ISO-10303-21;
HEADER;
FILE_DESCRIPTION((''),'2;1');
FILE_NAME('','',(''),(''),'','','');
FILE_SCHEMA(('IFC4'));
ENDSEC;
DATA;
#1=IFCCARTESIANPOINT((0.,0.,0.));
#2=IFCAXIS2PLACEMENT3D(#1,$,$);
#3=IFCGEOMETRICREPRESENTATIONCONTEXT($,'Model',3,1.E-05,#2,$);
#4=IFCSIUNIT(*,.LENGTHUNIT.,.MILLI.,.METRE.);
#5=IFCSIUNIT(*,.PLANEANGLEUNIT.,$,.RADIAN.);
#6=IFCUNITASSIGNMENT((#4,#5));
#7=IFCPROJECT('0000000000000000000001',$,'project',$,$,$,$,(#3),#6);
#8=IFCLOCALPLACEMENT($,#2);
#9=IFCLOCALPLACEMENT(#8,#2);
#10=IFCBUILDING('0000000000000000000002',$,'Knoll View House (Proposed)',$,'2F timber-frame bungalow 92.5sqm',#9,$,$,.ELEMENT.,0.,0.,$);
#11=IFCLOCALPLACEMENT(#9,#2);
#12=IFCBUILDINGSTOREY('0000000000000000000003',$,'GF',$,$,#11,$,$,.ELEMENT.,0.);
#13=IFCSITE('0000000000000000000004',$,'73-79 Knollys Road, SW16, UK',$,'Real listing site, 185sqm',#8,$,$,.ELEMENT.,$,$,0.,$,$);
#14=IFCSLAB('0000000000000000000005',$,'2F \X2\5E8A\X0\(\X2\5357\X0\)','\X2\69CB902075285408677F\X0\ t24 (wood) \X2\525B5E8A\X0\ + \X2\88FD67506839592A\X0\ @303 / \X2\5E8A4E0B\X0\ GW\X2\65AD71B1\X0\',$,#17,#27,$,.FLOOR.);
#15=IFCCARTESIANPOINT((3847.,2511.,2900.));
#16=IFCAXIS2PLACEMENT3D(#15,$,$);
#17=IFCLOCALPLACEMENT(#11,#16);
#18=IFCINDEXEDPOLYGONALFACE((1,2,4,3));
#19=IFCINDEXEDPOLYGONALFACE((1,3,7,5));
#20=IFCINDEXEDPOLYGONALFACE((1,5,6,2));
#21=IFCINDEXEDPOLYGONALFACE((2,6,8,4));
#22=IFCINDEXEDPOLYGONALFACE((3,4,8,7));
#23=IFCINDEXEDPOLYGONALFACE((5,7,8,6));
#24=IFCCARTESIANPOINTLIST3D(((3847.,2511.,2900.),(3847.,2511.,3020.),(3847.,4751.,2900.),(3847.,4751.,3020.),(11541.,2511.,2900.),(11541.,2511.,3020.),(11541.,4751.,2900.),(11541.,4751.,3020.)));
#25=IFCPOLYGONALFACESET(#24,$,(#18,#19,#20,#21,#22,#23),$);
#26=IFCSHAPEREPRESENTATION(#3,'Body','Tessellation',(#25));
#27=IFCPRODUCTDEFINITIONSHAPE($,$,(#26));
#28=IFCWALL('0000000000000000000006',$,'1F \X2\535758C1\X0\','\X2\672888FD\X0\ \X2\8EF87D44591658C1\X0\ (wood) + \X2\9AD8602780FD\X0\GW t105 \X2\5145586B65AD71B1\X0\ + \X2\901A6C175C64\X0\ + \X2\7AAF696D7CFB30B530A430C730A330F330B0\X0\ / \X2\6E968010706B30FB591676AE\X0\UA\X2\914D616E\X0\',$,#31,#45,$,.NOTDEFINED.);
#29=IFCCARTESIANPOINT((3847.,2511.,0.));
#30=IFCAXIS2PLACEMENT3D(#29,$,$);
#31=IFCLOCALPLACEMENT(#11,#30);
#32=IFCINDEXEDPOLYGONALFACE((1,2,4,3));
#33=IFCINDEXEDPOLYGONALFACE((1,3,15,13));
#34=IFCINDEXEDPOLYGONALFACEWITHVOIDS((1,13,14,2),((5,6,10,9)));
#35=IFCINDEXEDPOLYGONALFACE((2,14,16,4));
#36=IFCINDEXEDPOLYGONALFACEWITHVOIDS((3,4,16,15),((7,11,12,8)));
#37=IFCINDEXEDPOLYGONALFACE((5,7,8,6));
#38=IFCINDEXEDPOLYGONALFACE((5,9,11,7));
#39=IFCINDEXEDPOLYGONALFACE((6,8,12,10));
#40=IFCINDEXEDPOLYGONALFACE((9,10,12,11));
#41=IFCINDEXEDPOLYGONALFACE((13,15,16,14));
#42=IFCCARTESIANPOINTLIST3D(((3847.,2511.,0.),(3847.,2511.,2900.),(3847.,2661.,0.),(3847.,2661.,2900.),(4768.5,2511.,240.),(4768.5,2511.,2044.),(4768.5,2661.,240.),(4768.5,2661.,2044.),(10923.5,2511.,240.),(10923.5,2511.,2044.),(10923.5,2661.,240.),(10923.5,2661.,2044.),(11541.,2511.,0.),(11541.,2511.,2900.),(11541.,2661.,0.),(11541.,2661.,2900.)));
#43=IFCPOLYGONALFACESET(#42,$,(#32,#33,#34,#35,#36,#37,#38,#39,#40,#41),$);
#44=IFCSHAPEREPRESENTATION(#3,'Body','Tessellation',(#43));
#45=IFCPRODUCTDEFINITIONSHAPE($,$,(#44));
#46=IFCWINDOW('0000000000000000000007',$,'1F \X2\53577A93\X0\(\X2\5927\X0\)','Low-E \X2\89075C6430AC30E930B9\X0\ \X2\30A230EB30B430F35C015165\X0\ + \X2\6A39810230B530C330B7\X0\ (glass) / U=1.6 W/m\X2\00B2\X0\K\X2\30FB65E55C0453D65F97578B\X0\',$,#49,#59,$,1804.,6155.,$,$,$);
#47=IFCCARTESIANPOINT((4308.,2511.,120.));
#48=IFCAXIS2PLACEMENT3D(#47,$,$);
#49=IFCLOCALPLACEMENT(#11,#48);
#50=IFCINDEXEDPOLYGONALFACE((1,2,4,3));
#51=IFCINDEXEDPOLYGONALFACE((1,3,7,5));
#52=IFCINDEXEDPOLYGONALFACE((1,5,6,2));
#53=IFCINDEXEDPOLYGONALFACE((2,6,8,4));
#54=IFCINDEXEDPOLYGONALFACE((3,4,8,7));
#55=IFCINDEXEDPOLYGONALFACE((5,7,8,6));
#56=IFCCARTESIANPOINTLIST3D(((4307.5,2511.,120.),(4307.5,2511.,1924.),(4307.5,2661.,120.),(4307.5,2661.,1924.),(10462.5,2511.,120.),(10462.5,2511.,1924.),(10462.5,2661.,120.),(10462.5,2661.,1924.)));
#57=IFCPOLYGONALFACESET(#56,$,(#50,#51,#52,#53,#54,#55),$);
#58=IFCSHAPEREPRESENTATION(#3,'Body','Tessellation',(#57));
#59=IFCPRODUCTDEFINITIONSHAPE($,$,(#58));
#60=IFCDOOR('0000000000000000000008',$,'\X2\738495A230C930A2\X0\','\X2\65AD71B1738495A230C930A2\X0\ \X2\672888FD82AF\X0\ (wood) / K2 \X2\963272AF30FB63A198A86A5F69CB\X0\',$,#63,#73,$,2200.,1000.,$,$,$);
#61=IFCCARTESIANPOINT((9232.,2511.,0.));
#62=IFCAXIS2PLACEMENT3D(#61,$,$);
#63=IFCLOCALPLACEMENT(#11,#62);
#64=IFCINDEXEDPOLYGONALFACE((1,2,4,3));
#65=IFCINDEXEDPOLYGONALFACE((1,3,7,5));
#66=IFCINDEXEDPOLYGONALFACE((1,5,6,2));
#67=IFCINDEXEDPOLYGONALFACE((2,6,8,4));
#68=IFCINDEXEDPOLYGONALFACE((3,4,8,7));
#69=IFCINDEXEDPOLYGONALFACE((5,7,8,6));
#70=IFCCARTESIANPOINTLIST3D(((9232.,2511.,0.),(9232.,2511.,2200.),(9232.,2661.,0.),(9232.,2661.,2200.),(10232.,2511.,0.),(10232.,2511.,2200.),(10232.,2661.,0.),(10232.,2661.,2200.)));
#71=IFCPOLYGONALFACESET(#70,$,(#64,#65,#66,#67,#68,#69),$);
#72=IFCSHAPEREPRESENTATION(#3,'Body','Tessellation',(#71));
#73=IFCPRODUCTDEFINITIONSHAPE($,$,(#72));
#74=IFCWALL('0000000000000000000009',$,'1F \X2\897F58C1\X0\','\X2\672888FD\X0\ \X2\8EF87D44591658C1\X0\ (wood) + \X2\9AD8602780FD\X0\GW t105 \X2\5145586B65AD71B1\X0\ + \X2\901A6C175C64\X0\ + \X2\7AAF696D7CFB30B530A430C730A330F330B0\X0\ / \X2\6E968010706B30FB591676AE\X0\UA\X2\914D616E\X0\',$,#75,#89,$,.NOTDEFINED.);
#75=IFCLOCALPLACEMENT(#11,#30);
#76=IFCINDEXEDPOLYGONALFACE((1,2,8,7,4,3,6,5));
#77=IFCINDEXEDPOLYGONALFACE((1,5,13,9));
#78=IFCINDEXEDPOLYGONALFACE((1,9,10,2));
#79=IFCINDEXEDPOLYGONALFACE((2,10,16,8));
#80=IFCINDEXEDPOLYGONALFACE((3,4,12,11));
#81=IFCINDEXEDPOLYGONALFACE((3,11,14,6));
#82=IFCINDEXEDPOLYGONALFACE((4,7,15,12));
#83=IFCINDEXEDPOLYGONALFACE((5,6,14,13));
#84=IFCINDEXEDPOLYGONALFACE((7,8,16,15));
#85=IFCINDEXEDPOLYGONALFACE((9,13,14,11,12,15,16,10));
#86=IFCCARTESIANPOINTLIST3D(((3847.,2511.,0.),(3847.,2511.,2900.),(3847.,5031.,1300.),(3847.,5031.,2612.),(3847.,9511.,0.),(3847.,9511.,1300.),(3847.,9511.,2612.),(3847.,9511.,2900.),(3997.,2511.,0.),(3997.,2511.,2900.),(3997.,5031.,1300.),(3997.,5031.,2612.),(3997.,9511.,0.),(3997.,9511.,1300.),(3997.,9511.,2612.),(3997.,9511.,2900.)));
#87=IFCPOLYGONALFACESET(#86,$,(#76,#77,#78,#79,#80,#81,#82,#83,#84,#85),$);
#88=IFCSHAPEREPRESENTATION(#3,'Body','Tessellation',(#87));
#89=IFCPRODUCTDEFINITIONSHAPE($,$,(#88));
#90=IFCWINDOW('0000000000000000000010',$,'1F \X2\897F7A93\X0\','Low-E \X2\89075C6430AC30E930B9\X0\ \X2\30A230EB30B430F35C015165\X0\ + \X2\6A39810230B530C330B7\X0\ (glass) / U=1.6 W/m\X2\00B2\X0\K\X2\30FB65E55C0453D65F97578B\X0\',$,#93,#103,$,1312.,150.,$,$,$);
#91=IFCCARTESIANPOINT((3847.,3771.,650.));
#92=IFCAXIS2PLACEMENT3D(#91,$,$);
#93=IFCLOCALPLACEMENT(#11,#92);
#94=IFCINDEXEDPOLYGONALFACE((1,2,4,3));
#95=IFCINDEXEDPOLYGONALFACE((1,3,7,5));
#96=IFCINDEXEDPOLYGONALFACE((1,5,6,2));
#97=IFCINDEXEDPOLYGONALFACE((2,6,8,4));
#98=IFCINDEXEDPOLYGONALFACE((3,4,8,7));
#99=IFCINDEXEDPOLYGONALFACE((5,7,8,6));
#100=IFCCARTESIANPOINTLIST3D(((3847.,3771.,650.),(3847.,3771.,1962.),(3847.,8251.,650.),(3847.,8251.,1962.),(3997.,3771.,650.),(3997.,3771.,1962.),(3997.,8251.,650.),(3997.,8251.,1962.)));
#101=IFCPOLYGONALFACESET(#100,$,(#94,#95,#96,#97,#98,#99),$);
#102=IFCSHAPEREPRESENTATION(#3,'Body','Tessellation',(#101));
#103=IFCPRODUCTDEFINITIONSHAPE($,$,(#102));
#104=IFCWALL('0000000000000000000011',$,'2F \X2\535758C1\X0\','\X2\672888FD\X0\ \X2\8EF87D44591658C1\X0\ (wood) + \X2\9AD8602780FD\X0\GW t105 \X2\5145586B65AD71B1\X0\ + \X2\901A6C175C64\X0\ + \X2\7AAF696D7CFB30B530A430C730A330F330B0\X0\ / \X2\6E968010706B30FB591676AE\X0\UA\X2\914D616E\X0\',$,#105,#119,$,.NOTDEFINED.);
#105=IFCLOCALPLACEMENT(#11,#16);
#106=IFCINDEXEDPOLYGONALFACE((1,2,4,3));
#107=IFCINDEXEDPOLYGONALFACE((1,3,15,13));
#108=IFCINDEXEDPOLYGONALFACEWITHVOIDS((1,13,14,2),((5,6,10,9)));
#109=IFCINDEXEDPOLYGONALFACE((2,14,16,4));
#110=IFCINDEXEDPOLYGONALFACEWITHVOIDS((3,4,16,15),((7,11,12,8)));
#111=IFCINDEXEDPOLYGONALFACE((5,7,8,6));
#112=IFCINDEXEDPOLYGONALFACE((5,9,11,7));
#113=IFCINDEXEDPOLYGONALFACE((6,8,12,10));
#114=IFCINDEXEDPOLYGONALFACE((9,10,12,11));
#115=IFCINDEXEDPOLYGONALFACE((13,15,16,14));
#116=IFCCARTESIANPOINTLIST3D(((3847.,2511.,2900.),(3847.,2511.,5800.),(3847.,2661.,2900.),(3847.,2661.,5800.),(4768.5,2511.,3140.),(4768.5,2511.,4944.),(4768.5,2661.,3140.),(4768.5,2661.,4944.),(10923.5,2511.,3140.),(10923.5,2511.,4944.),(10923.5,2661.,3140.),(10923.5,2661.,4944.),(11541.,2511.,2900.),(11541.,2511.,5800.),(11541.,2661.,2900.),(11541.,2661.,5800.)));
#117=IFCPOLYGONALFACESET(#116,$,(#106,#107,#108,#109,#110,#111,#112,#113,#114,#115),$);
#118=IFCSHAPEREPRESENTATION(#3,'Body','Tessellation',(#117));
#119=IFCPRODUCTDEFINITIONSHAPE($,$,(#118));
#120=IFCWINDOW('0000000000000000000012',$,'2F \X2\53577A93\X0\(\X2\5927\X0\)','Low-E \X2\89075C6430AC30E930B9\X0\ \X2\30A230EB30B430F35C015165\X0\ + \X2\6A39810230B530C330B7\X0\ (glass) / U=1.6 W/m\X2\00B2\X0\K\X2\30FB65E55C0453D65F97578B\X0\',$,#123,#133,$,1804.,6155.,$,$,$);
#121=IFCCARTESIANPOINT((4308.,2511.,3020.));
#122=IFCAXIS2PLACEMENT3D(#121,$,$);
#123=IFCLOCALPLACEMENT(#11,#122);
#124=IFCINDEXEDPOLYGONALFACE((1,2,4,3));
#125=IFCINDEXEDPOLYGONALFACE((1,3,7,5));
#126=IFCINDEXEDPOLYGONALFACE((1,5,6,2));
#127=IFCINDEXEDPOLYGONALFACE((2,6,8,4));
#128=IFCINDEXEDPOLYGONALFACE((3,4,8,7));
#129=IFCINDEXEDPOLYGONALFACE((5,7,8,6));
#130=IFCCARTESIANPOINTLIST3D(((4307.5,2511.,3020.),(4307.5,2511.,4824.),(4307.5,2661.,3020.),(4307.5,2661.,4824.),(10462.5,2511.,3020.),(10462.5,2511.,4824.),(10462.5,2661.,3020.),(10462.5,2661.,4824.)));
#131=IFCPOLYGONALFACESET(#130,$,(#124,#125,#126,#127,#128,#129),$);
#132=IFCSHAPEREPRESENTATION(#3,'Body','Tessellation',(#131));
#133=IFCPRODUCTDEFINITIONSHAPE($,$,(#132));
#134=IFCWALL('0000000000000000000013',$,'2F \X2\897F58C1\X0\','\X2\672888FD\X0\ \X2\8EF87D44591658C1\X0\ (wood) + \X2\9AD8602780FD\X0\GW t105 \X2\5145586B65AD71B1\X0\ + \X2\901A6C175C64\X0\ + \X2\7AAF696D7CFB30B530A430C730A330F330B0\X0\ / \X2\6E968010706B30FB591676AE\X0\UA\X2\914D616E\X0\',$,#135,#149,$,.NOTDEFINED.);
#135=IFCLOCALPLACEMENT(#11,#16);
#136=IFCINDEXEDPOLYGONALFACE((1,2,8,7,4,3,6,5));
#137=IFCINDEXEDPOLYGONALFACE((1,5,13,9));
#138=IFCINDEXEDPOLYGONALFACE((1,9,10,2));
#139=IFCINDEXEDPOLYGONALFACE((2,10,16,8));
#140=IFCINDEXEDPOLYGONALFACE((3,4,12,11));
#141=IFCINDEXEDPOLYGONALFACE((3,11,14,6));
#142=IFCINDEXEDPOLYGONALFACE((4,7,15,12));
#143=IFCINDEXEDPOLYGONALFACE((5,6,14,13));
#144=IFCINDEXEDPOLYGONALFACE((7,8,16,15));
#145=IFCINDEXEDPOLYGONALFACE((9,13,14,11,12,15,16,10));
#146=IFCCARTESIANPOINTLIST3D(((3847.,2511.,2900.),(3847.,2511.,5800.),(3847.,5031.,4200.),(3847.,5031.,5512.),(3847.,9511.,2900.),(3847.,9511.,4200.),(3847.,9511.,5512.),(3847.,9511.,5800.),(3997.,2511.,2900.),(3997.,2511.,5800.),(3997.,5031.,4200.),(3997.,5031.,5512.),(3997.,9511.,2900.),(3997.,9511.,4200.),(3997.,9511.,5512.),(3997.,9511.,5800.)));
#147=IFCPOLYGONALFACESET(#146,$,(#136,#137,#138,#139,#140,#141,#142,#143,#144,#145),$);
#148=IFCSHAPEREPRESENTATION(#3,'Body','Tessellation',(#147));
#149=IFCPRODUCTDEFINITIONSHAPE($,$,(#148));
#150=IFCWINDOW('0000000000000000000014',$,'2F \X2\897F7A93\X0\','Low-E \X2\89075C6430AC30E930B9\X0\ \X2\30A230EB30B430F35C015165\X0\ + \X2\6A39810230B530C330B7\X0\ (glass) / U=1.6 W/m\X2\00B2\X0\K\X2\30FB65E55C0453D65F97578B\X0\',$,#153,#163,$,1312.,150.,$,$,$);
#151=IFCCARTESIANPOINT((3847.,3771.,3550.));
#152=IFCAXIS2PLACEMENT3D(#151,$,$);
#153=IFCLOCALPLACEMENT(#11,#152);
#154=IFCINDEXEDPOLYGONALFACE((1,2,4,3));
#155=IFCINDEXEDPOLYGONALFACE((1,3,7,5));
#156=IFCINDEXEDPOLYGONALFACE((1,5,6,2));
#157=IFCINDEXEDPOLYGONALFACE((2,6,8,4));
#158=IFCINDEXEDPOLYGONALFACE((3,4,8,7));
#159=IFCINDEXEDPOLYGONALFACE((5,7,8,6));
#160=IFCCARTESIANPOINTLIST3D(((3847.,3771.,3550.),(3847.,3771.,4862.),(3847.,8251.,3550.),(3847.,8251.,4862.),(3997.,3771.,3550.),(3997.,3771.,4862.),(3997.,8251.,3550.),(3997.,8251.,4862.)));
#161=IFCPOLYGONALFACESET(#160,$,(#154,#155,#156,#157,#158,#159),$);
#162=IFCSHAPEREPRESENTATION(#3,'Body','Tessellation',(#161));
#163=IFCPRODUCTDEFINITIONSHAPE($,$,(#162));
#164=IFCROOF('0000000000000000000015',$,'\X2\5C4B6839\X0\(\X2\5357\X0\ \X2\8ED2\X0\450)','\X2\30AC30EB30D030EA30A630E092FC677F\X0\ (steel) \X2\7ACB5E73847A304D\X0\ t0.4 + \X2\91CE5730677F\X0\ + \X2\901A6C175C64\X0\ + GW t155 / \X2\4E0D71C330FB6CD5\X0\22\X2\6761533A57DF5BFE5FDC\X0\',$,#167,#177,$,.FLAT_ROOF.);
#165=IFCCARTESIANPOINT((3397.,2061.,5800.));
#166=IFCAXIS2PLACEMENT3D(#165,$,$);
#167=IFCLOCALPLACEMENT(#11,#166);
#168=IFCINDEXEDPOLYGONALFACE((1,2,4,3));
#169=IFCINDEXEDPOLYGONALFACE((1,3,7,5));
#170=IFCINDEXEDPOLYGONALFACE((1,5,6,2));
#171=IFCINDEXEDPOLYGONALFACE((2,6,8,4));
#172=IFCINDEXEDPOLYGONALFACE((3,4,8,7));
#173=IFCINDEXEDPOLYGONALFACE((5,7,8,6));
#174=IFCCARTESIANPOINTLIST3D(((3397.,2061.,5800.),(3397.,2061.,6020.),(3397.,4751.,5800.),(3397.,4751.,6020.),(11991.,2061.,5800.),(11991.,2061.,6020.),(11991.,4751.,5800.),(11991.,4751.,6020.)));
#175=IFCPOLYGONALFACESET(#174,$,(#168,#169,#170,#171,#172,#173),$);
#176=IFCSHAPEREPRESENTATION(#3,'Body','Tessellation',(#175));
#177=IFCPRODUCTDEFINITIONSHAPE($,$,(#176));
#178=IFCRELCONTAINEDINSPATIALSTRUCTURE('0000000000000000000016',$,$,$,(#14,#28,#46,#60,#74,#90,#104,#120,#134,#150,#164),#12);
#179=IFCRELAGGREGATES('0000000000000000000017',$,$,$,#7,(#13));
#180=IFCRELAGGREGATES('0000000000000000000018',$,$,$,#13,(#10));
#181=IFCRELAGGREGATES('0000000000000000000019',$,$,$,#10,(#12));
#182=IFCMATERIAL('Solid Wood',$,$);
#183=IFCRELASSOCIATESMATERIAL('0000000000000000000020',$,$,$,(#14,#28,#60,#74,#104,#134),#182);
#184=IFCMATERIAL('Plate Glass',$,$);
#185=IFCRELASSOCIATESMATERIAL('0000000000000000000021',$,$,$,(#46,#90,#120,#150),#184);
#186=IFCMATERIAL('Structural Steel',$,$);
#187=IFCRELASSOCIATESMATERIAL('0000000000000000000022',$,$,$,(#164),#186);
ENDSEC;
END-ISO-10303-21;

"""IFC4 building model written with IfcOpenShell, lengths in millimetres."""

from ifc_helpers import new_model, si_unit, frame, frame_2d, origin, place, context, project, spatial, rectangle, extrude, material, element, fill, save


model = new_model("IFC4")

# Units and contexts
model_context = context("Model", 3, precision=1e-05, world=origin())
ifc_project = project(units=[si_unit("LENGTHUNIT", "METRE", prefix="MILLI"), si_unit("PLANEANGLEUNIT", "RADIAN")], contexts=[model_context])

# Site, building, storey
site_placement = place(None, origin())
site = spatial("IfcSite", under=ifc_project, at=site_placement, Name="73-79 Knollys Road, SW16, UK", ObjectType="Real listing site, 185sqm", CompositionType="ELEMENT", RefElevation=0.0)
building_placement = place(site_placement, origin())
building = spatial("IfcBuilding", under=site, at=building_placement, Name="Knoll View House (Proposed)", ObjectType="2F timber-frame bungalow 92.5sqm", CompositionType="ELEMENT", ElevationOfRefHeight=0.0, ElevationOfTerrain=0.0)
storey_placement = place(building_placement, origin())
storey = spatial("IfcBuildingStorey", under=building, at=storey_placement, Name="GF", CompositionType="ELEMENT", Elevation=0.0)

# Slab
ifc_material_1 = material(Name="Solid Wood")
slab_1_placement = place(storey_placement, frame((3847.0, 2511.0, 2900.0)))
element("IfcSlab", 1, at=slab_1_placement, inside=storey, material=ifc_material_1, Name="2F 床(南)", Description="構造用合板 t24 (wood) 剛床 + 製材根太 @303 / 床下 GW断熱", PredefinedType="FLOOR", context=model_context, shape_type="SweptSolid", body=[
    extrude(rectangle(XDim=7694.0, YDim=2240.0, at=frame_2d((3847.0, 1120.0))), frame((3847.0, 2511.0, 2900.0)), (0.0, 0.0, 1.0), 120.0),
])

# Wall, openings, window, door
wall_1_placement = place(storey_placement, frame((3847.0, 2511.0, 0.0)))
wall_1 = element("IfcWall", 2, at=wall_1_placement, inside=storey, material=ifc_material_1, Name="1F 南壁", Description="木製 軸組外壁 (wood) + 高性能GW t105 充填断熱 + 通気層 + 窯業系サイディング / 準耐火・外皮UA配慮", PredefinedType="NOTDEFINED", context=model_context, shape_type="SweptSolid", body=[
    extrude(rectangle(XDim=7694.0, YDim=150.0, at=frame_2d((3847.0, 75.0))), frame((3847.0, 2511.0, 0.0)), (0.0, 0.0, 1.0), 2900.0),
])
opening_1_placement = place(storey_placement, frame((4308.0, 2511.0, 120.0)))
opening_1 = element("IfcOpeningElement", 3, at=opening_1_placement, cuts=wall_1, PredefinedType="NOTDEFINED", context=model_context, shape_type="SweptSolid", body=[
    extrude(rectangle(XDim=6155.0, YDim=150.0, at=frame_2d((3077.0, 75.0))), frame((4308.0, 2511.0, 120.0)), (0.0, 0.0, 1.0), 1804.0),
])
opening_2_placement = place(storey_placement, frame((9232.0, 2511.0, 0.0)))
opening_2 = element("IfcOpeningElement", 4, at=opening_2_placement, cuts=wall_1, PredefinedType="NOTDEFINED", context=model_context, shape_type="SweptSolid", body=[
    extrude(rectangle(XDim=1000.0, YDim=150.0, at=frame_2d((500.0, 75.0))), frame((9232.0, 2511.0, 0.0)), (0.0, 0.0, 1.0), 2200.0),
])
ifc_material_2 = material(Name="Plate Glass")
window_1_placement = place(storey_placement, frame((4308.0, 2511.0, 120.0)))
window_1 = element("IfcWindow", 5, at=window_1_placement, inside=storey, material=ifc_material_2, Name="1F 南窓(大)", Description="Low-E 複層ガラス アルゴン封入 + 樹脂サッシ (glass) / U=1.6 W/m²K・日射取得型", OverallHeight=1804.0, OverallWidth=6155.0, context=model_context, shape_type="SweptSolid", body=[
    extrude(rectangle(XDim=6155.0, YDim=150.0, at=frame_2d((3077.0, 75.0))), frame((4308.0, 2511.0, 120.0)), (0.0, 0.0, 1.0), 1804.0),
])
fill(opening_1, window_1)
door_placement = place(storey_placement, frame((9232.0, 2511.0, 0.0)))
door = element("IfcDoor", 6, at=door_placement, inside=storey, material=ifc_material_1, Name="玄関ドア", Description="断熱玄関ドア 木製芯 (wood) / K2 防犯・採風機構", OverallHeight=2200.0, OverallWidth=1000.0, context=model_context, shape_type="SweptSolid", body=[
    extrude(rectangle(XDim=1000.0, YDim=150.0, at=frame_2d((500.0, 75.0))), frame((9232.0, 2511.0, 0.0)), (0.0, 0.0, 1.0), 2200.0),
])
fill(opening_2, door)

# Walls, openings, windows
wall_2_placement = place(storey_placement, frame((3847.0, 2511.0, 0.0)))
wall_2 = element("IfcWall", 7, at=wall_2_placement, inside=storey, material=ifc_material_1, Name="1F 西壁", Description="木製 軸組外壁 (wood) + 高性能GW t105 充填断熱 + 通気層 + 窯業系サイディング / 準耐火・外皮UA配慮", PredefinedType="NOTDEFINED", context=model_context, shape_type="SweptSolid", body=[
    extrude(rectangle(XDim=150.0, YDim=7000.0, at=frame_2d((75.0, 3500.0))), frame((3847.0, 2511.0, 0.0)), (0.0, 0.0, 1.0), 2900.0),
])
opening_3_placement = place(storey_placement, frame((3847.0, 3771.0, 650.0)))
opening_3 = element("IfcOpeningElement", 8, at=opening_3_placement, cuts=wall_2, PredefinedType="NOTDEFINED", context=model_context, shape_type="SweptSolid", body=[
    extrude(rectangle(XDim=150.0, YDim=4480.0, at=frame_2d((75.0, 2240.0))), frame((3847.0, 3771.0, 650.0)), (0.0, 0.0, 1.0), 1312.0),
])
window_2_placement = place(storey_placement, frame((3847.0, 3771.0, 650.0)))
window_2 = element("IfcWindow", 9, at=window_2_placement, inside=storey, material=ifc_material_2, Name="1F 西窓", Description="Low-E 複層ガラス アルゴン封入 + 樹脂サッシ (glass) / U=1.6 W/m²K・日射取得型", OverallHeight=1312.0, OverallWidth=150.0, context=model_context, shape_type="SweptSolid", body=[
    extrude(rectangle(XDim=150.0, YDim=4480.0, at=frame_2d((75.0, 2240.0))), frame((3847.0, 3771.0, 650.0)), (0.0, 0.0, 1.0), 1312.0),
])
fill(opening_3, window_2)
wall_3_placement = place(storey_placement, frame((3847.0, 2511.0, 2900.0)))
wall_3 = element("IfcWall", 10, at=wall_3_placement, inside=storey, material=ifc_material_1, Name="2F 南壁", Description="木製 軸組外壁 (wood) + 高性能GW t105 充填断熱 + 通気層 + 窯業系サイディング / 準耐火・外皮UA配慮", PredefinedType="NOTDEFINED", context=model_context, shape_type="SweptSolid", body=[
    extrude(rectangle(XDim=7694.0, YDim=150.0, at=frame_2d((3847.0, 75.0))), frame((3847.0, 2511.0, 2900.0)), (0.0, 0.0, 1.0), 2900.0),
])
opening_4_placement = place(storey_placement, frame((4308.0, 2511.0, 3020.0)))
opening_4 = element("IfcOpeningElement", 11, at=opening_4_placement, cuts=wall_3, PredefinedType="NOTDEFINED", context=model_context, shape_type="SweptSolid", body=[
    extrude(rectangle(XDim=6155.0, YDim=150.0, at=frame_2d((3077.0, 75.0))), frame((4308.0, 2511.0, 3020.0)), (0.0, 0.0, 1.0), 1804.0),
])
window_3_placement = place(storey_placement, frame((4308.0, 2511.0, 3020.0)))
window_3 = element("IfcWindow", 12, at=window_3_placement, inside=storey, material=ifc_material_2, Name="2F 南窓(大)", Description="Low-E 複層ガラス アルゴン封入 + 樹脂サッシ (glass) / U=1.6 W/m²K・日射取得型", OverallHeight=1804.0, OverallWidth=6155.0, context=model_context, shape_type="SweptSolid", body=[
    extrude(rectangle(XDim=6155.0, YDim=150.0, at=frame_2d((3077.0, 75.0))), frame((4308.0, 2511.0, 3020.0)), (0.0, 0.0, 1.0), 1804.0),
])
fill(opening_4, window_3)
wall_4_placement = place(storey_placement, frame((3847.0, 2511.0, 2900.0)))
wall_4 = element("IfcWall", 13, at=wall_4_placement, inside=storey, material=ifc_material_1, Name="2F 西壁", Description="木製 軸組外壁 (wood) + 高性能GW t105 充填断熱 + 通気層 + 窯業系サイディング / 準耐火・外皮UA配慮", PredefinedType="NOTDEFINED", context=model_context, shape_type="SweptSolid", body=[
    extrude(rectangle(XDim=150.0, YDim=7000.0, at=frame_2d((75.0, 3500.0))), frame((3847.0, 2511.0, 2900.0)), (0.0, 0.0, 1.0), 2900.0),
])
opening_5_placement = place(storey_placement, frame((3847.0, 3771.0, 3550.0)))
opening_5 = element("IfcOpeningElement", 14, at=opening_5_placement, cuts=wall_4, PredefinedType="NOTDEFINED", context=model_context, shape_type="SweptSolid", body=[
    extrude(rectangle(XDim=150.0, YDim=4480.0, at=frame_2d((75.0, 2240.0))), frame((3847.0, 3771.0, 3550.0)), (0.0, 0.0, 1.0), 1312.0),
])
window_4_placement = place(storey_placement, frame((3847.0, 3771.0, 3550.0)))
window_4 = element("IfcWindow", 15, at=window_4_placement, inside=storey, material=ifc_material_2, Name="2F 西窓", Description="Low-E 複層ガラス アルゴン封入 + 樹脂サッシ (glass) / U=1.6 W/m²K・日射取得型", OverallHeight=1312.0, OverallWidth=150.0, context=model_context, shape_type="SweptSolid", body=[
    extrude(rectangle(XDim=150.0, YDim=4480.0, at=frame_2d((75.0, 2240.0))), frame((3847.0, 3771.0, 3550.0)), (0.0, 0.0, 1.0), 1312.0),
])
fill(opening_5, window_4)

# Roof
ifc_material_3 = material(Name="Structural Steel")
roof_1_placement = place(storey_placement, frame((3397.0, 2061.0, 5800.0)))
element("IfcRoof", 16, at=roof_1_placement, inside=storey, material=ifc_material_3, Name="屋根(南 軒450)", Description="ガルバリウム鋼板 (steel) 立平葺き t0.4 + 野地板 + 通気層 + GW t155 / 不燃・法22条区域対応", PredefinedType="FLAT_ROOF", context=model_context, shape_type="SweptSolid", body=[
    extrude(rectangle(XDim=8594.0, YDim=2690.0, at=frame_2d((4297.0, 1345.0))), frame((3397.0, 2061.0, 5800.0)), (0.0, 0.0, 1.0), 220.0),
])

save(model, "model.ifc")
